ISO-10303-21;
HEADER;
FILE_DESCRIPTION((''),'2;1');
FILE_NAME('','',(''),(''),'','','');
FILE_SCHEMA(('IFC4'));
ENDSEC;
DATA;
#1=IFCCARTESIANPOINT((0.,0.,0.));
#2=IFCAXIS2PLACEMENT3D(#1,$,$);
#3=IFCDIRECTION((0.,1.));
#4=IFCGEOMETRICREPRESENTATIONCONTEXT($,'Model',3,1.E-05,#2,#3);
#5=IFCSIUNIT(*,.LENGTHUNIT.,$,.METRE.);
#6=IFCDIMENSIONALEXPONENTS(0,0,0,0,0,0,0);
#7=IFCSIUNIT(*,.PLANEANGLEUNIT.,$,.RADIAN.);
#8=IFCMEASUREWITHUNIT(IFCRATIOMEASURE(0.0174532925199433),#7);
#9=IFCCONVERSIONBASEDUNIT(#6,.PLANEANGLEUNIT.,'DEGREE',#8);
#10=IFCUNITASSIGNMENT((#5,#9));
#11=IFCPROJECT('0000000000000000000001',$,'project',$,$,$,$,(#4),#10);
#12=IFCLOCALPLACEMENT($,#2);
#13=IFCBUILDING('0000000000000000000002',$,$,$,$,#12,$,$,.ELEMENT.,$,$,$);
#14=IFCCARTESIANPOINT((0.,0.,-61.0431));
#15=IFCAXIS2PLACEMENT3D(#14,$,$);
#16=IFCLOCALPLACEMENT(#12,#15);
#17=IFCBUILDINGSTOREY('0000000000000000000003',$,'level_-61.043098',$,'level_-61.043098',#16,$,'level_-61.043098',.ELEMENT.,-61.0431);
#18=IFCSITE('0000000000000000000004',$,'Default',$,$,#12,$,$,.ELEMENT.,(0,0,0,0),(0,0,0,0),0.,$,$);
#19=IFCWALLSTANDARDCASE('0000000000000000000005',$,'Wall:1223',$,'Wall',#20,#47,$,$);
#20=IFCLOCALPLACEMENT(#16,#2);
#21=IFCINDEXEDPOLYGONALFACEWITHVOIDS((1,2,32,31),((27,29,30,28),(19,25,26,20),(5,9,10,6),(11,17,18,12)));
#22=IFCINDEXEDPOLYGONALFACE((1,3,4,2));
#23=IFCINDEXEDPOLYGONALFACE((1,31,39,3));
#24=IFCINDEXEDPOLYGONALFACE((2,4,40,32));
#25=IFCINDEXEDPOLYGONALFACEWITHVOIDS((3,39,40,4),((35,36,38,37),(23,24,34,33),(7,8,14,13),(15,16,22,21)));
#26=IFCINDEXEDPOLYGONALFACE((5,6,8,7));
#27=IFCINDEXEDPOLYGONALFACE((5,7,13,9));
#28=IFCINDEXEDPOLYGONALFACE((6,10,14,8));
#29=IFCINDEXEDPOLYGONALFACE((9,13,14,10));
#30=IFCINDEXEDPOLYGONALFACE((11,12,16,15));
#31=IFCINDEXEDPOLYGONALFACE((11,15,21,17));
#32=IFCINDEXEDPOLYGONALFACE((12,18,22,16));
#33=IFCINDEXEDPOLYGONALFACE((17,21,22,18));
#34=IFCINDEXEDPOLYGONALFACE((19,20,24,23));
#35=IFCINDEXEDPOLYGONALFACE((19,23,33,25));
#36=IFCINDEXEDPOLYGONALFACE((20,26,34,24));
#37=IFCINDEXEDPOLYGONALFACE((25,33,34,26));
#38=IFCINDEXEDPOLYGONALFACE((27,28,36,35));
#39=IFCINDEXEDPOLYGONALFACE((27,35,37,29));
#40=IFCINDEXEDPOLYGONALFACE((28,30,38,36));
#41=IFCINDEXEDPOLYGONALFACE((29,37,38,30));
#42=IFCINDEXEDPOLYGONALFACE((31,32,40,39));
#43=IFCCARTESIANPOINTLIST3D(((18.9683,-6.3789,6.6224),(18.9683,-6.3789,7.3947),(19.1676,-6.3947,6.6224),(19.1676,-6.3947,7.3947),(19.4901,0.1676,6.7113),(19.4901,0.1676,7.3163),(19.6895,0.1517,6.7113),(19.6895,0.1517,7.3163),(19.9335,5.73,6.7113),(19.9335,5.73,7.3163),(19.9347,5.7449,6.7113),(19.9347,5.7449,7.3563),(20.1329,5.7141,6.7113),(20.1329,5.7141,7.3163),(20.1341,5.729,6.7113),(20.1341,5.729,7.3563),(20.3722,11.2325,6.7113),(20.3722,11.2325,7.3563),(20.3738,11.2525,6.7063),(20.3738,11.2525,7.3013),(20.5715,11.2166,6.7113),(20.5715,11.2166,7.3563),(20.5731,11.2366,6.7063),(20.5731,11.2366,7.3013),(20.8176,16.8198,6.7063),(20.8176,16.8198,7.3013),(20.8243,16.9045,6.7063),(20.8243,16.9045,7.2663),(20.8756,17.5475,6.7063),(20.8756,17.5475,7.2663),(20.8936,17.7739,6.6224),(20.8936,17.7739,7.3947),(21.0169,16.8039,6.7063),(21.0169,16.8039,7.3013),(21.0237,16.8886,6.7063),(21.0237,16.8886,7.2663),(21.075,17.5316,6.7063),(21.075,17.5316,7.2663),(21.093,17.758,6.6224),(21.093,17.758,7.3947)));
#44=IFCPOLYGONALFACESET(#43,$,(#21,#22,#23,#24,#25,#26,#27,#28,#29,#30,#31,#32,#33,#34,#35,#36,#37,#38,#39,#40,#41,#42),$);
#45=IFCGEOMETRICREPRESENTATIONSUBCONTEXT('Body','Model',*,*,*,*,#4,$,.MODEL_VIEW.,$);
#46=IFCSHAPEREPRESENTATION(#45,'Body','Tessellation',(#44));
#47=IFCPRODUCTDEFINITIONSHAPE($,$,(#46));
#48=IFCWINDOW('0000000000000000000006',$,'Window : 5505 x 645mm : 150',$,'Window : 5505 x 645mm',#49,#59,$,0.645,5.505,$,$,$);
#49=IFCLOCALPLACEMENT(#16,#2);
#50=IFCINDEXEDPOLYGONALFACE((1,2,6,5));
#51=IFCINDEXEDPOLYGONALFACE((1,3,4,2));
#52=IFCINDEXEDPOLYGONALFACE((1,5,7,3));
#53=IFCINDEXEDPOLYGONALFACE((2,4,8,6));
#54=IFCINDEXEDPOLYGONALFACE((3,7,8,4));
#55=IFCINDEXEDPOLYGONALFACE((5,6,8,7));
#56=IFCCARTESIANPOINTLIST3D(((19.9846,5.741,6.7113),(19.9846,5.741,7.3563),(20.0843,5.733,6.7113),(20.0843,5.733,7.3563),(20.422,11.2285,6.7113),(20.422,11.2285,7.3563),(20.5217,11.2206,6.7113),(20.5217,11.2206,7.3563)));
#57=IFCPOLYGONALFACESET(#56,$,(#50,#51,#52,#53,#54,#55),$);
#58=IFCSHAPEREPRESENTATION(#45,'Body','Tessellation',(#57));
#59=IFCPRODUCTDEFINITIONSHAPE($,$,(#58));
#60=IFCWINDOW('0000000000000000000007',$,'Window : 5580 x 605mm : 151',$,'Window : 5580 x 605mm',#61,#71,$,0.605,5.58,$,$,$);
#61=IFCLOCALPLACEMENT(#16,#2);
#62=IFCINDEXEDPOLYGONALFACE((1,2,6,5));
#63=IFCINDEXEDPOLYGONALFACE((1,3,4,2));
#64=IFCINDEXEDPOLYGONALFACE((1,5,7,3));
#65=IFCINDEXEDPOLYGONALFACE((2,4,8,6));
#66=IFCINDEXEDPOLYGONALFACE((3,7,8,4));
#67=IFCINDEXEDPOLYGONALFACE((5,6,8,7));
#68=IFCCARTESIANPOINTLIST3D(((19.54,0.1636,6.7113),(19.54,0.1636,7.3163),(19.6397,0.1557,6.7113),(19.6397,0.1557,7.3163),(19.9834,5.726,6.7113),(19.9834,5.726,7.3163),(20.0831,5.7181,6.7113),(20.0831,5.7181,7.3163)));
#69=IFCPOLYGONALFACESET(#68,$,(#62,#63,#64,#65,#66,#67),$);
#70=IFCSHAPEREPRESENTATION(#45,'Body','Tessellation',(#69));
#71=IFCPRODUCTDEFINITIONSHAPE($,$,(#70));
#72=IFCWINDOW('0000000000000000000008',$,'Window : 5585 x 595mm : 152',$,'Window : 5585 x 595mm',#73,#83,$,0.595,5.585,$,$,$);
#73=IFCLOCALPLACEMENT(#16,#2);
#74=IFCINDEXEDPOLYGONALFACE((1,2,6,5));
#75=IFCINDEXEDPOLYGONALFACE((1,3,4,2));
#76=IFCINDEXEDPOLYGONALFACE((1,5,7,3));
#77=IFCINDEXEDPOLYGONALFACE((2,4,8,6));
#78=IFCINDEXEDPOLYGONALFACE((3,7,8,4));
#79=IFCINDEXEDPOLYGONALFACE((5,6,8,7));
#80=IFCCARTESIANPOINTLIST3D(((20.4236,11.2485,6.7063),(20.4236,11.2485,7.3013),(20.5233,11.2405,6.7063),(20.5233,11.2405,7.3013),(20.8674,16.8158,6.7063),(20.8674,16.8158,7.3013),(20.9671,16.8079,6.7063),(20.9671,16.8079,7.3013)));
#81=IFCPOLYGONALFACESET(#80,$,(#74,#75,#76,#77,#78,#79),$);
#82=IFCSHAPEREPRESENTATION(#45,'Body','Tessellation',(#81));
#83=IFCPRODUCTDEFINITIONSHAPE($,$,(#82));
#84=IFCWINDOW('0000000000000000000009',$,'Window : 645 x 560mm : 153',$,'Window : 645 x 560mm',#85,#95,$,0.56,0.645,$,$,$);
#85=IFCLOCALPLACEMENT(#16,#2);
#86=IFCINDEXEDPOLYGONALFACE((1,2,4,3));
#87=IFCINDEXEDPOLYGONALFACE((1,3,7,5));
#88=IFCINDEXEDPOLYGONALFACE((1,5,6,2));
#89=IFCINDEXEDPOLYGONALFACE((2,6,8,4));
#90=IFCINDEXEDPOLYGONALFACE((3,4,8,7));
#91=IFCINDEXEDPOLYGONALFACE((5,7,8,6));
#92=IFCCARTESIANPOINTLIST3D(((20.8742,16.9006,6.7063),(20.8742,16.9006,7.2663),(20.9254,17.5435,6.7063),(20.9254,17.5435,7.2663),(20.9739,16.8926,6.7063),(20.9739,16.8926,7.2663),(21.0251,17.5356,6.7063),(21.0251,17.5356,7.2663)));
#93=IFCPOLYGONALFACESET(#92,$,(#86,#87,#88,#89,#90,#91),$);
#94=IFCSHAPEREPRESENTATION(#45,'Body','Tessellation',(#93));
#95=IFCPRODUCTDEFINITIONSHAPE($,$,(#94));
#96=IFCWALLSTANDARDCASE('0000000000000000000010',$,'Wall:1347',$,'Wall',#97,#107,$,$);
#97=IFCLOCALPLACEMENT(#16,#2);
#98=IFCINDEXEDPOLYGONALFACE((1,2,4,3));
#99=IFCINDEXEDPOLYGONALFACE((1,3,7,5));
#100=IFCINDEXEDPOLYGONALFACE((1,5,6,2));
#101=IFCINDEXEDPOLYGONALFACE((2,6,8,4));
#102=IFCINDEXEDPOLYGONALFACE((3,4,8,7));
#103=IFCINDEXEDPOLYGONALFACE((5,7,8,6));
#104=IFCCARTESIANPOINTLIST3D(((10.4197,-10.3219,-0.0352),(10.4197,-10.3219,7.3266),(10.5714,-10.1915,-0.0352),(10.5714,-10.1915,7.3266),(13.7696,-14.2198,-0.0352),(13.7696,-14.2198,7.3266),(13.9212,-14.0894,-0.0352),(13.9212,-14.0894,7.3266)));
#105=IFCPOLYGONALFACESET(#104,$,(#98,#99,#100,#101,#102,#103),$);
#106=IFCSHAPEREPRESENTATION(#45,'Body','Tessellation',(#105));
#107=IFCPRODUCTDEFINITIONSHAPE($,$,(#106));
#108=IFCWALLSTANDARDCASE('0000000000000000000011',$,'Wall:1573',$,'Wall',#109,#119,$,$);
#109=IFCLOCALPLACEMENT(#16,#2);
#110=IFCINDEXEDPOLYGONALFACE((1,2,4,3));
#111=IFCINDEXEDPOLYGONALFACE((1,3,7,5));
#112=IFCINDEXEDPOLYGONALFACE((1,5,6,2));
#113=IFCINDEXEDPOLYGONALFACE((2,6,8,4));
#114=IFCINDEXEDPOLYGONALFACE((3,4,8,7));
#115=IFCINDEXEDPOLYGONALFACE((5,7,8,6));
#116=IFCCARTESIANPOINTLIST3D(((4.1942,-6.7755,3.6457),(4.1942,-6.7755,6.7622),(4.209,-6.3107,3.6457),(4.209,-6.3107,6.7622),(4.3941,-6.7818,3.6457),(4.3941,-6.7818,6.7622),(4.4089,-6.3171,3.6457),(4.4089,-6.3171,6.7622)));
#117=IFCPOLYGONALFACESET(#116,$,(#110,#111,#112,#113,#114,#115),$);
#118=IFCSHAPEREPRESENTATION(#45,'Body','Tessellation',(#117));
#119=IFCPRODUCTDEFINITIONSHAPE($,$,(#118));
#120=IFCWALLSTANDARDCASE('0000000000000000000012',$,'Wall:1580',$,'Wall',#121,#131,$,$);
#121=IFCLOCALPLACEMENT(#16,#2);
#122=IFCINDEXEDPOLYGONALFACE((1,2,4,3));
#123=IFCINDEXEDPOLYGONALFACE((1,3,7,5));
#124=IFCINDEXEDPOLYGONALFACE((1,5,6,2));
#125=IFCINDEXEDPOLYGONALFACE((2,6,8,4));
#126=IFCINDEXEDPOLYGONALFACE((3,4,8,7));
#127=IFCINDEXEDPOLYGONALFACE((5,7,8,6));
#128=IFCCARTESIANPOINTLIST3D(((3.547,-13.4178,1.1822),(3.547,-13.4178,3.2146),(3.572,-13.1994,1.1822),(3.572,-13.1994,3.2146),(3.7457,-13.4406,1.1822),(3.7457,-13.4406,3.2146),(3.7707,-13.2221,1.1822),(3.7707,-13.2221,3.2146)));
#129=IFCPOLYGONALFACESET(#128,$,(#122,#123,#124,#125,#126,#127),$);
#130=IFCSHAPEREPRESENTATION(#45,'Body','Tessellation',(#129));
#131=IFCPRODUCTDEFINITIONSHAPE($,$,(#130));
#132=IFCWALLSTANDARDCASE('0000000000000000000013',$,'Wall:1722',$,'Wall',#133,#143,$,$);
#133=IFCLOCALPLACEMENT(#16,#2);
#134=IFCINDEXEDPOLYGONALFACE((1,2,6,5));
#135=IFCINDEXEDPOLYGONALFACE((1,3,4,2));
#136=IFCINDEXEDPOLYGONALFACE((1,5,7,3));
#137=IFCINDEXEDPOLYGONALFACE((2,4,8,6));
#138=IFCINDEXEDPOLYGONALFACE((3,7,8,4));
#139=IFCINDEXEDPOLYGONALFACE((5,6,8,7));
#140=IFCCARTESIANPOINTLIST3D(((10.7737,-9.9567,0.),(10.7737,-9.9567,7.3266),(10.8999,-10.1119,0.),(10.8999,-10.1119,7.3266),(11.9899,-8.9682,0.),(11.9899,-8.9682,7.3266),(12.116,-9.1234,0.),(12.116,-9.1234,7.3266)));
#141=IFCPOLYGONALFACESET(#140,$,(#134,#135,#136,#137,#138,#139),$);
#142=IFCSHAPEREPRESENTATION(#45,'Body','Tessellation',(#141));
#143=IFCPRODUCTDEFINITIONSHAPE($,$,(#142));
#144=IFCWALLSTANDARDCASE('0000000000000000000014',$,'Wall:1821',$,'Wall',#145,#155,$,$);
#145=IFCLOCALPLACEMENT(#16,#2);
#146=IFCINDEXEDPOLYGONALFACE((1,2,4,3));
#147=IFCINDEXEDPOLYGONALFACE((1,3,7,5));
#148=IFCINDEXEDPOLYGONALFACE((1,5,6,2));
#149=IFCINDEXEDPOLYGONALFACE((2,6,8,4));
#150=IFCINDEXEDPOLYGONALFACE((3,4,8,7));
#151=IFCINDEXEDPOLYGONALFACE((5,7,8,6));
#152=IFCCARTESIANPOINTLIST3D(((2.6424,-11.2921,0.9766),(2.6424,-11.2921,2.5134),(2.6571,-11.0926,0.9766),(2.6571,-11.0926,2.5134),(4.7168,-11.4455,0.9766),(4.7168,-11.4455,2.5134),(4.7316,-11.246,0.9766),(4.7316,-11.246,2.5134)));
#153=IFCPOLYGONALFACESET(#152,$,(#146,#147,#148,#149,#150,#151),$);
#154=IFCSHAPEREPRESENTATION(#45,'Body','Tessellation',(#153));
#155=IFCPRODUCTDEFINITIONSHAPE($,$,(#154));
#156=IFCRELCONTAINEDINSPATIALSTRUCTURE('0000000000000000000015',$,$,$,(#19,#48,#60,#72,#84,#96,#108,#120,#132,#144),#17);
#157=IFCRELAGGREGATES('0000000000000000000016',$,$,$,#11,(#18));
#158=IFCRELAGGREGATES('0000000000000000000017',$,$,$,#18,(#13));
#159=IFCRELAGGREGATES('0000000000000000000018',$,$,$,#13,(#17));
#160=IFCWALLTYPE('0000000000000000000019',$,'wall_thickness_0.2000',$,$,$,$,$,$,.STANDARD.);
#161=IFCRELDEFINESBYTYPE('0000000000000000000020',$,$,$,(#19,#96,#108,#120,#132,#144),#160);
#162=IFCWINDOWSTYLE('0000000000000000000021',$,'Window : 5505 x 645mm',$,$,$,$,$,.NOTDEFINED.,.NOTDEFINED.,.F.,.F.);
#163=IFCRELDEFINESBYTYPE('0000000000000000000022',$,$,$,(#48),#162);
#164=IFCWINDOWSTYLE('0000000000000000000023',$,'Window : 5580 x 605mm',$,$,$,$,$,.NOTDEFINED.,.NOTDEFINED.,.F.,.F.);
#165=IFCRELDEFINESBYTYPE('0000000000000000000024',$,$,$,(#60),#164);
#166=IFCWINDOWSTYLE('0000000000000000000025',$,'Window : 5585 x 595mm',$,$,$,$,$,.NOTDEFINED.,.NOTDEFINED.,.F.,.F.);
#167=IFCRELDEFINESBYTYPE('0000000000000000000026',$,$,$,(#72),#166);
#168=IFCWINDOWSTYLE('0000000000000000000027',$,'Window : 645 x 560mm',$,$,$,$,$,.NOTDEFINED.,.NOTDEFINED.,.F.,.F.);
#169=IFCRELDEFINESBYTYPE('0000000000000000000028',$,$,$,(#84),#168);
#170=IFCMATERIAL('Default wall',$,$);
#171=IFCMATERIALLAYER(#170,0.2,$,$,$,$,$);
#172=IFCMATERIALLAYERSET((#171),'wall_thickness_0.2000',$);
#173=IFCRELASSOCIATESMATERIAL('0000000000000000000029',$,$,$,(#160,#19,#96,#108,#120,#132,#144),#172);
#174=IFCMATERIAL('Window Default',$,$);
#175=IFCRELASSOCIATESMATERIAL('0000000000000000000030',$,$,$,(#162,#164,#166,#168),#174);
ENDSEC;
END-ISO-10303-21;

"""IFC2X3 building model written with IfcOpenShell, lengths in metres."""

from ifc_helpers import new_model, entity, si_unit, converted_unit, direction, frame, frame_2d, origin, origin_2d_with_axis, place, context, subcontext, project, spatial, polyline, rectangle, outline, extrude, source, transform, mapped, material, layer, layer_set, layer_usage, type_object, type_shapes, element, fill, save


model = new_model("IFC2X3")

# Units and contexts
model_context = context("Model", 3, precision=1e-05, world=origin(), true_north=direction((0.0, 1.0)))
body_context = subcontext(model_context, "Body", "Model", "MODEL_VIEW")
ifc_project = project(units=[si_unit("LENGTHUNIT", "METRE"), converted_unit("PLANEANGLEUNIT", "DEGREE", entity("IfcRatioMeasure", 0.0174532925199433), si_unit("PLANEANGLEUNIT", "RADIAN"), dimensions=[0, 0, 0, 0, 0, 0, 0])], contexts=[model_context])

# Site, building, storey
placement_1 = place(None, origin())
site = spatial("IfcSite", under=ifc_project, at=placement_1, Name="Default", CompositionType="ELEMENT", RefLatitude=(0, 0, 0, 0), RefLongitude=(0, 0, 0, 0), RefElevation=0.0)
building = spatial("IfcBuilding", under=site, at=placement_1, CompositionType="ELEMENT")
storey_placement = place(placement_1, frame((0.0, 0.0, -61.0431)))
storey = spatial("IfcBuildingStorey", under=building, at=storey_placement, Name="level_-61.043098", ObjectType="level_-61.043098", LongName="level_-61.043098", CompositionType="ELEMENT", Elevation=-61.0431)

# Shared definitions
ifc_material_1 = material(Name="Default wall")
ifc_layer = layer(ifc_material_1, 0.2)
ifc_layer_set = layer_set([ifc_layer], Name="wall_thickness_0.2000")
ifc_layer_usage = layer_usage(ifc_layer_set, "AXIS2", "POSITIVE", -0.1)
wall_type = type_object("IfcWallType", Name="wall_thickness_0.2000", PredefinedType="STANDARD", material=ifc_layer_set)

# Wall, openings, windows
placement_2 = place(placement_1, frame((0.0, 0.0, -54.4207)))
wall_1_placement = place(placement_2, frame((19.068, -6.3868, 0.0), z_axis=(0.0, 0.0, 1.0), x_axis=(0.079464, 0.996838, 0.0)))
wall_1 = element("IfcWallStandardCase", 1, at=wall_1_placement, inside=storey, type_object=wall_type, material=ifc_layer_usage, Name="Wall:1223", ObjectType="Wall", context=body_context, shape_type="SweptSolid", body=[
    extrude(outline(polyline([(24.2294, -0.1), (24.2294, 0.1), (0.0, 0.1), (0.0, -0.1), (24.2294, -0.1)])), origin(), (0.0, 0.0, 1.0), 0.7723),
])
opening_1_placement = place(wall_1_placement, frame((12.1622, -0.1, 0.0889)))
opening_1 = element("IfcOpeningElement", 2, at=opening_1_placement, cuts=wall_1, ObjectType="Opening", context=body_context, shape_type="SweptSolid", body=[
    extrude(rectangle(XDim=5.505, YDim=0.645, at=frame_2d((0.3225, 2.7525), x_axis=(0.0, 1.0))), frame((0.0, 0.0, 0.0), z_axis=(0.0, 1.0, 0.0), x_axis=(0.0, 0.0, 1.0)), (0.0, 0.0, 1.0), 0.2),
])
opening_2_placement = place(wall_1_placement, frame((6.5672, -0.1, 0.0889)))
opening_2 = element("IfcOpeningElement", 3, at=opening_2_placement, cuts=wall_1, ObjectType="Opening", context=body_context, shape_type="SweptSolid", body=[
    extrude(rectangle(XDim=5.58, YDim=0.605, at=frame_2d((0.3025, 2.79), x_axis=(0.0, 1.0))), frame((0.0, 0.0, 0.0), z_axis=(0.0, 1.0, 0.0), x_axis=(0.0, 0.0, 1.0)), (0.0, 0.0, 1.0), 0.2),
])
opening_3_placement = place(wall_1_placement, frame((17.6872, -0.1, 0.0839)))
opening_3 = element("IfcOpeningElement", 4, at=opening_3_placement, cuts=wall_1, ObjectType="Opening", context=body_context, shape_type="SweptSolid", body=[
    extrude(rectangle(XDim=5.585, YDim=0.595, at=frame_2d((0.2975, 2.7925), x_axis=(0.0, 1.0))), frame((0.0, 0.0, 0.0), z_axis=(0.0, 1.0, 0.0), x_axis=(0.0, 0.0, 1.0)), (0.0, 0.0, 1.0), 0.2),
])
opening_4_placement = place(wall_1_placement, frame((23.3572, -0.1, 0.0839)))
opening_4 = element("IfcOpeningElement", 5, at=opening_4_placement, cuts=wall_1, ObjectType="Opening", context=body_context, shape_type="SweptSolid", body=[
    extrude(rectangle(XDim=0.645, YDim=0.56, at=frame_2d((0.28, 0.3225), x_axis=(0.0, 1.0))), frame((0.0, 0.0, 0.0), z_axis=(0.0, 1.0, 0.0), x_axis=(0.0, 0.0, 1.0)), (0.0, 0.0, 1.0), 0.2),
])
ifc_material_2 = material(Name="Window Default")
window_style_1 = type_object("IfcWindowStyle", Name="Window : 5505 x 645mm", ConstructionType="NOTDEFINED", OperationType="NOTDEFINED", ParameterTakesPrecedence=False, Sizeable=False, material=ifc_material_2)
shared_shape_1 = source(origin(), body_context, "Body", "SweptSolid", [
    extrude(rectangle(XDim=0.1, YDim=5.505, at=origin_2d_with_axis()), frame((2.7525, 0.1, 0.0), z_axis=(0.0, 0.0, 1.0), x_axis=(0.0, 1.0, 0.0)), (0.0, 0.0, 1.0), 0.645),
])
type_shapes(window_style_1, [shared_shape_1])
window_1_placement = place(opening_1_placement, origin())
window_1 = element("IfcWindow", 6, at=window_1_placement, inside=storey, type_object=window_style_1, Name="Window : 5505 x 645mm : 150", ObjectType="Window : 5505 x 645mm", OverallHeight=0.645, OverallWidth=5.505, context=body_context, shape_type="MappedRepresentation", body=[
    mapped(shared_shape_1, transform((0.0, 0.0, 0.0), scale=1.0)),
])
fill(opening_1, window_1)
window_style_2 = type_object("IfcWindowStyle", Name="Window : 5580 x 605mm", ConstructionType="NOTDEFINED", OperationType="NOTDEFINED", ParameterTakesPrecedence=False, Sizeable=False, material=ifc_material_2)
shared_shape_2 = source(origin(), body_context, "Body", "SweptSolid", [
    extrude(rectangle(XDim=0.1, YDim=5.58, at=origin_2d_with_axis()), frame((2.79, 0.1, 0.0), z_axis=(0.0, 0.0, 1.0), x_axis=(0.0, 1.0, 0.0)), (0.0, 0.0, 1.0), 0.605),
])
type_shapes(window_style_2, [shared_shape_2])
window_2_placement = place(opening_2_placement, origin())
window_2 = element("IfcWindow", 7, at=window_2_placement, inside=storey, type_object=window_style_2, Name="Window : 5580 x 605mm : 151", ObjectType="Window : 5580 x 605mm", OverallHeight=0.605, OverallWidth=5.58, context=body_context, shape_type="MappedRepresentation", body=[
    mapped(shared_shape_2, transform((0.0, 0.0, 0.0), scale=1.0)),
])
fill(opening_2, window_2)
window_style_3 = type_object("IfcWindowStyle", Name="Window : 5585 x 595mm", ConstructionType="NOTDEFINED", OperationType="NOTDEFINED", ParameterTakesPrecedence=False, Sizeable=False, material=ifc_material_2)
shared_shape_3 = source(origin(), body_context, "Body", "SweptSolid", [
    extrude(rectangle(XDim=0.1, YDim=5.585, at=origin_2d_with_axis()), frame((2.7925, 0.1, 0.0), z_axis=(0.0, 0.0, 1.0), x_axis=(0.0, 1.0, 0.0)), (0.0, 0.0, 1.0), 0.595),
])
type_shapes(window_style_3, [shared_shape_3])
window_3_placement = place(opening_3_placement, origin())
window_3 = element("IfcWindow", 8, at=window_3_placement, inside=storey, type_object=window_style_3, Name="Window : 5585 x 595mm : 152", ObjectType="Window : 5585 x 595mm", OverallHeight=0.595, OverallWidth=5.585, context=body_context, shape_type="MappedRepresentation", body=[
    mapped(shared_shape_3, transform((0.0, 0.0, 0.0), scale=1.0)),
])
fill(opening_3, window_3)
window_style_4 = type_object("IfcWindowStyle", Name="Window : 645 x 560mm", ConstructionType="NOTDEFINED", OperationType="NOTDEFINED", ParameterTakesPrecedence=False, Sizeable=False, material=ifc_material_2)
shared_shape_4 = source(origin(), body_context, "Body", "SweptSolid", [
    extrude(rectangle(XDim=0.1, YDim=0.645, at=origin_2d_with_axis()), frame((0.3225, 0.1, 0.0), z_axis=(0.0, 0.0, 1.0), x_axis=(0.0, 1.0, 0.0)), (0.0, 0.0, 1.0), 0.56),
])
type_shapes(window_style_4, [shared_shape_4])
window_4_placement = place(opening_4_placement, origin())
window_4 = element("IfcWindow", 9, at=window_4_placement, inside=storey, type_object=window_style_4, Name="Window : 645 x 560mm : 153", ObjectType="Window : 645 x 560mm", OverallHeight=0.56, OverallWidth=0.645, context=body_context, shape_type="MappedRepresentation", body=[
    mapped(shared_shape_4, transform((0.0, 0.0, 0.0), scale=1.0)),
])
fill(opening_4, window_4)

# Walls
placement_3 = place(placement_1, frame((0.0, 0.0, -61.0783)))
wall_2_placement = place(placement_3, frame((10.4955, -10.2567, 0.0), z_axis=(0.0, 0.0, 1.0), x_axis=(0.651774, -0.758413, 0.0)))
element("IfcWallStandardCase", 10, at=wall_2_placement, inside=storey, type_object=wall_type, material=ifc_layer_usage, Name="Wall:1347", ObjectType="Wall", context=body_context, shape_type="SweptSolid", body=[
    extrude(outline(polyline([(5.1396, -0.1), (5.1396, 0.1), (0.0, 0.1), (0.0, -0.1), (5.1396, -0.1)])), origin(), (0.0, 0.0, 1.0), 7.3618),
])
placement_4 = place(placement_1, frame((0.0, 0.0, -57.3974)))
wall_3_placement = place(placement_4, frame((4.3089, -6.3139, 0.0), z_axis=(0.0, 0.0, 1.0), x_axis=(-0.031834, -0.999493, 0.0)))
element("IfcWallStandardCase", 11, at=wall_3_placement, inside=storey, type_object=wall_type, material=ifc_layer_usage, Name="Wall:1573", ObjectType="Wall", context=body_context, shape_type="SweptSolid", body=[
    extrude(outline(polyline([(0.465, -0.1), (0.465, 0.1), (0.0, 0.1), (0.0, -0.1), (0.465, -0.1)])), origin(), (0.0, 0.0, 1.0), 3.1165),
])
placement_5 = place(placement_1, frame((0.0, 0.0, -59.8609)))
wall_4_placement = place(placement_5, frame((3.6714, -13.2108, 0.0), z_axis=(0.0, 0.0, 1.0), x_axis=(-0.1138, -0.993504, 0.0)))
element("IfcWallStandardCase", 12, at=wall_4_placement, inside=storey, type_object=wall_type, material=ifc_layer_usage, Name="Wall:1580", ObjectType="Wall", context=body_context, shape_type="SweptSolid", body=[
    extrude(outline(polyline([(0.2199, -0.1), (0.2199, 0.1), (0.0, 0.1), (0.0, -0.1), (0.2199, -0.1)])), origin(), (0.0, 0.0, 1.0), 2.0324),
])
wall_5_placement = place(storey_placement, frame((12.0529, -9.0458, 0.0), z_axis=(0.0, 0.0, 1.0), x_axis=(-0.775983, -0.630754, 0.0)))
element("IfcWallStandardCase", 13, at=wall_5_placement, inside=storey, type_object=wall_type, material=ifc_layer_usage, Name="Wall:1722", ObjectType="Wall", context=body_context, shape_type="SweptSolid", body=[
    extrude(outline(polyline([(1.5672, -0.1), (1.5672, 0.1), (0.0, 0.1), (0.0, -0.1), (1.5672, -0.1)])), origin(), (0.0, 0.0, 1.0), 7.3266),
])
placement_6 = place(placement_1, frame((0.0, 0.0, -60.0665)))
wall_6_placement = place(placement_6, frame((2.6497, -11.1924, 0.0), z_axis=(0.0, 0.0, 1.0), x_axis=(0.997278, -0.073732, 0.0)))
element("IfcWallStandardCase", 14, at=wall_6_placement, inside=storey, type_object=wall_type, material=ifc_layer_usage, Name="Wall:1821", ObjectType="Wall", context=body_context, shape_type="SweptSolid", body=[
    extrude(outline(polyline([(2.0801, -0.1), (2.0801, 0.1), (0.0, 0.1), (0.0, -0.1), (2.0801, -0.1)])), origin(), (0.0, 0.0, 1.0), 1.5369),
])

save(model, "model.ifc")
